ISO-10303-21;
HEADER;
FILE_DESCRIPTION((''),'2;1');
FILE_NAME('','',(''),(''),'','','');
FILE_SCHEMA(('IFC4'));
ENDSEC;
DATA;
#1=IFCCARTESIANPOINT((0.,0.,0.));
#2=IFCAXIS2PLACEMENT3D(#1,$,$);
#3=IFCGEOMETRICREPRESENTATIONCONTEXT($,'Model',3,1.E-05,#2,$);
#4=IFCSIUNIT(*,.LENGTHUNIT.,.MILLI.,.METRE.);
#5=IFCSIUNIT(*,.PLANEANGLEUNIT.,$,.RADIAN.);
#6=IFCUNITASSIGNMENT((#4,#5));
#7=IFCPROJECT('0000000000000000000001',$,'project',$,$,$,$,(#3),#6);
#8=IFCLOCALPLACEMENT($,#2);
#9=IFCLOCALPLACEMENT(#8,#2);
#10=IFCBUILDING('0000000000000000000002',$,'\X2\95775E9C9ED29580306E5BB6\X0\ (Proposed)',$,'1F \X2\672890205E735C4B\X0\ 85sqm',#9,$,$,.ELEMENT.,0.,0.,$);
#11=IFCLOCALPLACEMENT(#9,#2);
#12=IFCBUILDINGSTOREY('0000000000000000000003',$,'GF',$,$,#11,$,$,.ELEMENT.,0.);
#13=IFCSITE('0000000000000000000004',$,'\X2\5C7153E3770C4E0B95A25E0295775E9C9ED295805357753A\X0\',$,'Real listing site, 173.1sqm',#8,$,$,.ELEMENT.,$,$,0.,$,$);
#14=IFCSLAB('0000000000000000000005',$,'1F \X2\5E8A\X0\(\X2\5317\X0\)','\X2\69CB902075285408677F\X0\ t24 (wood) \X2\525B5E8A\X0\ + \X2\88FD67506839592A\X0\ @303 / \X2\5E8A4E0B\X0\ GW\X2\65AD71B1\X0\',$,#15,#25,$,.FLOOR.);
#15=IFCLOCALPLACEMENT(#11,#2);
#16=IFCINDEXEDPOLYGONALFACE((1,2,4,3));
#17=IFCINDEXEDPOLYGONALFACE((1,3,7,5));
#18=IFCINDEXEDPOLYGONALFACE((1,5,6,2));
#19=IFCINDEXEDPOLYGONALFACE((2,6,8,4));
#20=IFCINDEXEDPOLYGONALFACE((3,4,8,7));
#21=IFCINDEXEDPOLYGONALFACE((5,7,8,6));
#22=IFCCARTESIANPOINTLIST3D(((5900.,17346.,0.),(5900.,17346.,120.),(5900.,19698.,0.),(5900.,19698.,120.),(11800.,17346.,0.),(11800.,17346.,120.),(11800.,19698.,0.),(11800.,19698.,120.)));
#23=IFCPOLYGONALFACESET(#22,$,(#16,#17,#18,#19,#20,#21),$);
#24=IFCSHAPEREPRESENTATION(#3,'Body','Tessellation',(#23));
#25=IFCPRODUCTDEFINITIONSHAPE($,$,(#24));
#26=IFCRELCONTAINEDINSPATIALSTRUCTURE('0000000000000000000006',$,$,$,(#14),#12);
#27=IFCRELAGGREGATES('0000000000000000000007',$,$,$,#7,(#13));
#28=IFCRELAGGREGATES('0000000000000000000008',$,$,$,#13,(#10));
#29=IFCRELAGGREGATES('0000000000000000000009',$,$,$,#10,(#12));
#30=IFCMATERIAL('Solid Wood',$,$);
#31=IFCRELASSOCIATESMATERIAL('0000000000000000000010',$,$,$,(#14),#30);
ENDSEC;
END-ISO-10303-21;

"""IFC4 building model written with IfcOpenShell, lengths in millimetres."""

from ifc_helpers import new_model, si_unit, frame, frame_2d, origin, place, context, project, spatial, rectangle, extrude, material, element, save


model = new_model("IFC4")

# Units and contexts
model_context = context("Model", 3, precision=1e-05, world=origin())
ifc_project = project(units=[si_unit("LENGTHUNIT", "METRE", prefix="MILLI"), si_unit("PLANEANGLEUNIT", "RADIAN")], contexts=[model_context])

# Site, building, storey
site_placement = place(None, origin())
site = spatial("IfcSite", under=ifc_project, at=site_placement, Name="山口県下関市長府黒門南町", ObjectType="Real listing site, 173.1sqm", CompositionType="ELEMENT", RefElevation=0.0)
building_placement = place(site_placement, origin())
building = spatial("IfcBuilding", under=site, at=building_placement, Name="長府黒門の家 (Proposed)", ObjectType="1F 木造平屋 85sqm", CompositionType="ELEMENT", ElevationOfRefHeight=0.0, ElevationOfTerrain=0.0)
storey_placement = place(building_placement, origin())
storey = spatial("IfcBuildingStorey", under=building, at=storey_placement, Name="GF", CompositionType="ELEMENT", Elevation=0.0)

# Slab
ifc_material_1 = material(Name="Solid Wood")
slab_1_placement = place(storey_placement, frame((2950.0, 8673.0, 0.0)))
element("IfcSlab", 1, at=slab_1_placement, inside=storey, material=ifc_material_1, Name="1F 床(北)", Description="構造用合板 t24 (wood) 剛床 + 製材根太 @303 / 床下 GW断熱", PredefinedType="FLOOR", context=model_context, shape_type="SweptSolid", body=[
    extrude(rectangle(XDim=5900.0, YDim=2352.0, at=frame_2d((2950.0, 1176.0))), frame((2950.0, 8673.0, 0.0)), (0.0, 0.0, 1.0), 120.0),
])

save(model, "model.ifc")
